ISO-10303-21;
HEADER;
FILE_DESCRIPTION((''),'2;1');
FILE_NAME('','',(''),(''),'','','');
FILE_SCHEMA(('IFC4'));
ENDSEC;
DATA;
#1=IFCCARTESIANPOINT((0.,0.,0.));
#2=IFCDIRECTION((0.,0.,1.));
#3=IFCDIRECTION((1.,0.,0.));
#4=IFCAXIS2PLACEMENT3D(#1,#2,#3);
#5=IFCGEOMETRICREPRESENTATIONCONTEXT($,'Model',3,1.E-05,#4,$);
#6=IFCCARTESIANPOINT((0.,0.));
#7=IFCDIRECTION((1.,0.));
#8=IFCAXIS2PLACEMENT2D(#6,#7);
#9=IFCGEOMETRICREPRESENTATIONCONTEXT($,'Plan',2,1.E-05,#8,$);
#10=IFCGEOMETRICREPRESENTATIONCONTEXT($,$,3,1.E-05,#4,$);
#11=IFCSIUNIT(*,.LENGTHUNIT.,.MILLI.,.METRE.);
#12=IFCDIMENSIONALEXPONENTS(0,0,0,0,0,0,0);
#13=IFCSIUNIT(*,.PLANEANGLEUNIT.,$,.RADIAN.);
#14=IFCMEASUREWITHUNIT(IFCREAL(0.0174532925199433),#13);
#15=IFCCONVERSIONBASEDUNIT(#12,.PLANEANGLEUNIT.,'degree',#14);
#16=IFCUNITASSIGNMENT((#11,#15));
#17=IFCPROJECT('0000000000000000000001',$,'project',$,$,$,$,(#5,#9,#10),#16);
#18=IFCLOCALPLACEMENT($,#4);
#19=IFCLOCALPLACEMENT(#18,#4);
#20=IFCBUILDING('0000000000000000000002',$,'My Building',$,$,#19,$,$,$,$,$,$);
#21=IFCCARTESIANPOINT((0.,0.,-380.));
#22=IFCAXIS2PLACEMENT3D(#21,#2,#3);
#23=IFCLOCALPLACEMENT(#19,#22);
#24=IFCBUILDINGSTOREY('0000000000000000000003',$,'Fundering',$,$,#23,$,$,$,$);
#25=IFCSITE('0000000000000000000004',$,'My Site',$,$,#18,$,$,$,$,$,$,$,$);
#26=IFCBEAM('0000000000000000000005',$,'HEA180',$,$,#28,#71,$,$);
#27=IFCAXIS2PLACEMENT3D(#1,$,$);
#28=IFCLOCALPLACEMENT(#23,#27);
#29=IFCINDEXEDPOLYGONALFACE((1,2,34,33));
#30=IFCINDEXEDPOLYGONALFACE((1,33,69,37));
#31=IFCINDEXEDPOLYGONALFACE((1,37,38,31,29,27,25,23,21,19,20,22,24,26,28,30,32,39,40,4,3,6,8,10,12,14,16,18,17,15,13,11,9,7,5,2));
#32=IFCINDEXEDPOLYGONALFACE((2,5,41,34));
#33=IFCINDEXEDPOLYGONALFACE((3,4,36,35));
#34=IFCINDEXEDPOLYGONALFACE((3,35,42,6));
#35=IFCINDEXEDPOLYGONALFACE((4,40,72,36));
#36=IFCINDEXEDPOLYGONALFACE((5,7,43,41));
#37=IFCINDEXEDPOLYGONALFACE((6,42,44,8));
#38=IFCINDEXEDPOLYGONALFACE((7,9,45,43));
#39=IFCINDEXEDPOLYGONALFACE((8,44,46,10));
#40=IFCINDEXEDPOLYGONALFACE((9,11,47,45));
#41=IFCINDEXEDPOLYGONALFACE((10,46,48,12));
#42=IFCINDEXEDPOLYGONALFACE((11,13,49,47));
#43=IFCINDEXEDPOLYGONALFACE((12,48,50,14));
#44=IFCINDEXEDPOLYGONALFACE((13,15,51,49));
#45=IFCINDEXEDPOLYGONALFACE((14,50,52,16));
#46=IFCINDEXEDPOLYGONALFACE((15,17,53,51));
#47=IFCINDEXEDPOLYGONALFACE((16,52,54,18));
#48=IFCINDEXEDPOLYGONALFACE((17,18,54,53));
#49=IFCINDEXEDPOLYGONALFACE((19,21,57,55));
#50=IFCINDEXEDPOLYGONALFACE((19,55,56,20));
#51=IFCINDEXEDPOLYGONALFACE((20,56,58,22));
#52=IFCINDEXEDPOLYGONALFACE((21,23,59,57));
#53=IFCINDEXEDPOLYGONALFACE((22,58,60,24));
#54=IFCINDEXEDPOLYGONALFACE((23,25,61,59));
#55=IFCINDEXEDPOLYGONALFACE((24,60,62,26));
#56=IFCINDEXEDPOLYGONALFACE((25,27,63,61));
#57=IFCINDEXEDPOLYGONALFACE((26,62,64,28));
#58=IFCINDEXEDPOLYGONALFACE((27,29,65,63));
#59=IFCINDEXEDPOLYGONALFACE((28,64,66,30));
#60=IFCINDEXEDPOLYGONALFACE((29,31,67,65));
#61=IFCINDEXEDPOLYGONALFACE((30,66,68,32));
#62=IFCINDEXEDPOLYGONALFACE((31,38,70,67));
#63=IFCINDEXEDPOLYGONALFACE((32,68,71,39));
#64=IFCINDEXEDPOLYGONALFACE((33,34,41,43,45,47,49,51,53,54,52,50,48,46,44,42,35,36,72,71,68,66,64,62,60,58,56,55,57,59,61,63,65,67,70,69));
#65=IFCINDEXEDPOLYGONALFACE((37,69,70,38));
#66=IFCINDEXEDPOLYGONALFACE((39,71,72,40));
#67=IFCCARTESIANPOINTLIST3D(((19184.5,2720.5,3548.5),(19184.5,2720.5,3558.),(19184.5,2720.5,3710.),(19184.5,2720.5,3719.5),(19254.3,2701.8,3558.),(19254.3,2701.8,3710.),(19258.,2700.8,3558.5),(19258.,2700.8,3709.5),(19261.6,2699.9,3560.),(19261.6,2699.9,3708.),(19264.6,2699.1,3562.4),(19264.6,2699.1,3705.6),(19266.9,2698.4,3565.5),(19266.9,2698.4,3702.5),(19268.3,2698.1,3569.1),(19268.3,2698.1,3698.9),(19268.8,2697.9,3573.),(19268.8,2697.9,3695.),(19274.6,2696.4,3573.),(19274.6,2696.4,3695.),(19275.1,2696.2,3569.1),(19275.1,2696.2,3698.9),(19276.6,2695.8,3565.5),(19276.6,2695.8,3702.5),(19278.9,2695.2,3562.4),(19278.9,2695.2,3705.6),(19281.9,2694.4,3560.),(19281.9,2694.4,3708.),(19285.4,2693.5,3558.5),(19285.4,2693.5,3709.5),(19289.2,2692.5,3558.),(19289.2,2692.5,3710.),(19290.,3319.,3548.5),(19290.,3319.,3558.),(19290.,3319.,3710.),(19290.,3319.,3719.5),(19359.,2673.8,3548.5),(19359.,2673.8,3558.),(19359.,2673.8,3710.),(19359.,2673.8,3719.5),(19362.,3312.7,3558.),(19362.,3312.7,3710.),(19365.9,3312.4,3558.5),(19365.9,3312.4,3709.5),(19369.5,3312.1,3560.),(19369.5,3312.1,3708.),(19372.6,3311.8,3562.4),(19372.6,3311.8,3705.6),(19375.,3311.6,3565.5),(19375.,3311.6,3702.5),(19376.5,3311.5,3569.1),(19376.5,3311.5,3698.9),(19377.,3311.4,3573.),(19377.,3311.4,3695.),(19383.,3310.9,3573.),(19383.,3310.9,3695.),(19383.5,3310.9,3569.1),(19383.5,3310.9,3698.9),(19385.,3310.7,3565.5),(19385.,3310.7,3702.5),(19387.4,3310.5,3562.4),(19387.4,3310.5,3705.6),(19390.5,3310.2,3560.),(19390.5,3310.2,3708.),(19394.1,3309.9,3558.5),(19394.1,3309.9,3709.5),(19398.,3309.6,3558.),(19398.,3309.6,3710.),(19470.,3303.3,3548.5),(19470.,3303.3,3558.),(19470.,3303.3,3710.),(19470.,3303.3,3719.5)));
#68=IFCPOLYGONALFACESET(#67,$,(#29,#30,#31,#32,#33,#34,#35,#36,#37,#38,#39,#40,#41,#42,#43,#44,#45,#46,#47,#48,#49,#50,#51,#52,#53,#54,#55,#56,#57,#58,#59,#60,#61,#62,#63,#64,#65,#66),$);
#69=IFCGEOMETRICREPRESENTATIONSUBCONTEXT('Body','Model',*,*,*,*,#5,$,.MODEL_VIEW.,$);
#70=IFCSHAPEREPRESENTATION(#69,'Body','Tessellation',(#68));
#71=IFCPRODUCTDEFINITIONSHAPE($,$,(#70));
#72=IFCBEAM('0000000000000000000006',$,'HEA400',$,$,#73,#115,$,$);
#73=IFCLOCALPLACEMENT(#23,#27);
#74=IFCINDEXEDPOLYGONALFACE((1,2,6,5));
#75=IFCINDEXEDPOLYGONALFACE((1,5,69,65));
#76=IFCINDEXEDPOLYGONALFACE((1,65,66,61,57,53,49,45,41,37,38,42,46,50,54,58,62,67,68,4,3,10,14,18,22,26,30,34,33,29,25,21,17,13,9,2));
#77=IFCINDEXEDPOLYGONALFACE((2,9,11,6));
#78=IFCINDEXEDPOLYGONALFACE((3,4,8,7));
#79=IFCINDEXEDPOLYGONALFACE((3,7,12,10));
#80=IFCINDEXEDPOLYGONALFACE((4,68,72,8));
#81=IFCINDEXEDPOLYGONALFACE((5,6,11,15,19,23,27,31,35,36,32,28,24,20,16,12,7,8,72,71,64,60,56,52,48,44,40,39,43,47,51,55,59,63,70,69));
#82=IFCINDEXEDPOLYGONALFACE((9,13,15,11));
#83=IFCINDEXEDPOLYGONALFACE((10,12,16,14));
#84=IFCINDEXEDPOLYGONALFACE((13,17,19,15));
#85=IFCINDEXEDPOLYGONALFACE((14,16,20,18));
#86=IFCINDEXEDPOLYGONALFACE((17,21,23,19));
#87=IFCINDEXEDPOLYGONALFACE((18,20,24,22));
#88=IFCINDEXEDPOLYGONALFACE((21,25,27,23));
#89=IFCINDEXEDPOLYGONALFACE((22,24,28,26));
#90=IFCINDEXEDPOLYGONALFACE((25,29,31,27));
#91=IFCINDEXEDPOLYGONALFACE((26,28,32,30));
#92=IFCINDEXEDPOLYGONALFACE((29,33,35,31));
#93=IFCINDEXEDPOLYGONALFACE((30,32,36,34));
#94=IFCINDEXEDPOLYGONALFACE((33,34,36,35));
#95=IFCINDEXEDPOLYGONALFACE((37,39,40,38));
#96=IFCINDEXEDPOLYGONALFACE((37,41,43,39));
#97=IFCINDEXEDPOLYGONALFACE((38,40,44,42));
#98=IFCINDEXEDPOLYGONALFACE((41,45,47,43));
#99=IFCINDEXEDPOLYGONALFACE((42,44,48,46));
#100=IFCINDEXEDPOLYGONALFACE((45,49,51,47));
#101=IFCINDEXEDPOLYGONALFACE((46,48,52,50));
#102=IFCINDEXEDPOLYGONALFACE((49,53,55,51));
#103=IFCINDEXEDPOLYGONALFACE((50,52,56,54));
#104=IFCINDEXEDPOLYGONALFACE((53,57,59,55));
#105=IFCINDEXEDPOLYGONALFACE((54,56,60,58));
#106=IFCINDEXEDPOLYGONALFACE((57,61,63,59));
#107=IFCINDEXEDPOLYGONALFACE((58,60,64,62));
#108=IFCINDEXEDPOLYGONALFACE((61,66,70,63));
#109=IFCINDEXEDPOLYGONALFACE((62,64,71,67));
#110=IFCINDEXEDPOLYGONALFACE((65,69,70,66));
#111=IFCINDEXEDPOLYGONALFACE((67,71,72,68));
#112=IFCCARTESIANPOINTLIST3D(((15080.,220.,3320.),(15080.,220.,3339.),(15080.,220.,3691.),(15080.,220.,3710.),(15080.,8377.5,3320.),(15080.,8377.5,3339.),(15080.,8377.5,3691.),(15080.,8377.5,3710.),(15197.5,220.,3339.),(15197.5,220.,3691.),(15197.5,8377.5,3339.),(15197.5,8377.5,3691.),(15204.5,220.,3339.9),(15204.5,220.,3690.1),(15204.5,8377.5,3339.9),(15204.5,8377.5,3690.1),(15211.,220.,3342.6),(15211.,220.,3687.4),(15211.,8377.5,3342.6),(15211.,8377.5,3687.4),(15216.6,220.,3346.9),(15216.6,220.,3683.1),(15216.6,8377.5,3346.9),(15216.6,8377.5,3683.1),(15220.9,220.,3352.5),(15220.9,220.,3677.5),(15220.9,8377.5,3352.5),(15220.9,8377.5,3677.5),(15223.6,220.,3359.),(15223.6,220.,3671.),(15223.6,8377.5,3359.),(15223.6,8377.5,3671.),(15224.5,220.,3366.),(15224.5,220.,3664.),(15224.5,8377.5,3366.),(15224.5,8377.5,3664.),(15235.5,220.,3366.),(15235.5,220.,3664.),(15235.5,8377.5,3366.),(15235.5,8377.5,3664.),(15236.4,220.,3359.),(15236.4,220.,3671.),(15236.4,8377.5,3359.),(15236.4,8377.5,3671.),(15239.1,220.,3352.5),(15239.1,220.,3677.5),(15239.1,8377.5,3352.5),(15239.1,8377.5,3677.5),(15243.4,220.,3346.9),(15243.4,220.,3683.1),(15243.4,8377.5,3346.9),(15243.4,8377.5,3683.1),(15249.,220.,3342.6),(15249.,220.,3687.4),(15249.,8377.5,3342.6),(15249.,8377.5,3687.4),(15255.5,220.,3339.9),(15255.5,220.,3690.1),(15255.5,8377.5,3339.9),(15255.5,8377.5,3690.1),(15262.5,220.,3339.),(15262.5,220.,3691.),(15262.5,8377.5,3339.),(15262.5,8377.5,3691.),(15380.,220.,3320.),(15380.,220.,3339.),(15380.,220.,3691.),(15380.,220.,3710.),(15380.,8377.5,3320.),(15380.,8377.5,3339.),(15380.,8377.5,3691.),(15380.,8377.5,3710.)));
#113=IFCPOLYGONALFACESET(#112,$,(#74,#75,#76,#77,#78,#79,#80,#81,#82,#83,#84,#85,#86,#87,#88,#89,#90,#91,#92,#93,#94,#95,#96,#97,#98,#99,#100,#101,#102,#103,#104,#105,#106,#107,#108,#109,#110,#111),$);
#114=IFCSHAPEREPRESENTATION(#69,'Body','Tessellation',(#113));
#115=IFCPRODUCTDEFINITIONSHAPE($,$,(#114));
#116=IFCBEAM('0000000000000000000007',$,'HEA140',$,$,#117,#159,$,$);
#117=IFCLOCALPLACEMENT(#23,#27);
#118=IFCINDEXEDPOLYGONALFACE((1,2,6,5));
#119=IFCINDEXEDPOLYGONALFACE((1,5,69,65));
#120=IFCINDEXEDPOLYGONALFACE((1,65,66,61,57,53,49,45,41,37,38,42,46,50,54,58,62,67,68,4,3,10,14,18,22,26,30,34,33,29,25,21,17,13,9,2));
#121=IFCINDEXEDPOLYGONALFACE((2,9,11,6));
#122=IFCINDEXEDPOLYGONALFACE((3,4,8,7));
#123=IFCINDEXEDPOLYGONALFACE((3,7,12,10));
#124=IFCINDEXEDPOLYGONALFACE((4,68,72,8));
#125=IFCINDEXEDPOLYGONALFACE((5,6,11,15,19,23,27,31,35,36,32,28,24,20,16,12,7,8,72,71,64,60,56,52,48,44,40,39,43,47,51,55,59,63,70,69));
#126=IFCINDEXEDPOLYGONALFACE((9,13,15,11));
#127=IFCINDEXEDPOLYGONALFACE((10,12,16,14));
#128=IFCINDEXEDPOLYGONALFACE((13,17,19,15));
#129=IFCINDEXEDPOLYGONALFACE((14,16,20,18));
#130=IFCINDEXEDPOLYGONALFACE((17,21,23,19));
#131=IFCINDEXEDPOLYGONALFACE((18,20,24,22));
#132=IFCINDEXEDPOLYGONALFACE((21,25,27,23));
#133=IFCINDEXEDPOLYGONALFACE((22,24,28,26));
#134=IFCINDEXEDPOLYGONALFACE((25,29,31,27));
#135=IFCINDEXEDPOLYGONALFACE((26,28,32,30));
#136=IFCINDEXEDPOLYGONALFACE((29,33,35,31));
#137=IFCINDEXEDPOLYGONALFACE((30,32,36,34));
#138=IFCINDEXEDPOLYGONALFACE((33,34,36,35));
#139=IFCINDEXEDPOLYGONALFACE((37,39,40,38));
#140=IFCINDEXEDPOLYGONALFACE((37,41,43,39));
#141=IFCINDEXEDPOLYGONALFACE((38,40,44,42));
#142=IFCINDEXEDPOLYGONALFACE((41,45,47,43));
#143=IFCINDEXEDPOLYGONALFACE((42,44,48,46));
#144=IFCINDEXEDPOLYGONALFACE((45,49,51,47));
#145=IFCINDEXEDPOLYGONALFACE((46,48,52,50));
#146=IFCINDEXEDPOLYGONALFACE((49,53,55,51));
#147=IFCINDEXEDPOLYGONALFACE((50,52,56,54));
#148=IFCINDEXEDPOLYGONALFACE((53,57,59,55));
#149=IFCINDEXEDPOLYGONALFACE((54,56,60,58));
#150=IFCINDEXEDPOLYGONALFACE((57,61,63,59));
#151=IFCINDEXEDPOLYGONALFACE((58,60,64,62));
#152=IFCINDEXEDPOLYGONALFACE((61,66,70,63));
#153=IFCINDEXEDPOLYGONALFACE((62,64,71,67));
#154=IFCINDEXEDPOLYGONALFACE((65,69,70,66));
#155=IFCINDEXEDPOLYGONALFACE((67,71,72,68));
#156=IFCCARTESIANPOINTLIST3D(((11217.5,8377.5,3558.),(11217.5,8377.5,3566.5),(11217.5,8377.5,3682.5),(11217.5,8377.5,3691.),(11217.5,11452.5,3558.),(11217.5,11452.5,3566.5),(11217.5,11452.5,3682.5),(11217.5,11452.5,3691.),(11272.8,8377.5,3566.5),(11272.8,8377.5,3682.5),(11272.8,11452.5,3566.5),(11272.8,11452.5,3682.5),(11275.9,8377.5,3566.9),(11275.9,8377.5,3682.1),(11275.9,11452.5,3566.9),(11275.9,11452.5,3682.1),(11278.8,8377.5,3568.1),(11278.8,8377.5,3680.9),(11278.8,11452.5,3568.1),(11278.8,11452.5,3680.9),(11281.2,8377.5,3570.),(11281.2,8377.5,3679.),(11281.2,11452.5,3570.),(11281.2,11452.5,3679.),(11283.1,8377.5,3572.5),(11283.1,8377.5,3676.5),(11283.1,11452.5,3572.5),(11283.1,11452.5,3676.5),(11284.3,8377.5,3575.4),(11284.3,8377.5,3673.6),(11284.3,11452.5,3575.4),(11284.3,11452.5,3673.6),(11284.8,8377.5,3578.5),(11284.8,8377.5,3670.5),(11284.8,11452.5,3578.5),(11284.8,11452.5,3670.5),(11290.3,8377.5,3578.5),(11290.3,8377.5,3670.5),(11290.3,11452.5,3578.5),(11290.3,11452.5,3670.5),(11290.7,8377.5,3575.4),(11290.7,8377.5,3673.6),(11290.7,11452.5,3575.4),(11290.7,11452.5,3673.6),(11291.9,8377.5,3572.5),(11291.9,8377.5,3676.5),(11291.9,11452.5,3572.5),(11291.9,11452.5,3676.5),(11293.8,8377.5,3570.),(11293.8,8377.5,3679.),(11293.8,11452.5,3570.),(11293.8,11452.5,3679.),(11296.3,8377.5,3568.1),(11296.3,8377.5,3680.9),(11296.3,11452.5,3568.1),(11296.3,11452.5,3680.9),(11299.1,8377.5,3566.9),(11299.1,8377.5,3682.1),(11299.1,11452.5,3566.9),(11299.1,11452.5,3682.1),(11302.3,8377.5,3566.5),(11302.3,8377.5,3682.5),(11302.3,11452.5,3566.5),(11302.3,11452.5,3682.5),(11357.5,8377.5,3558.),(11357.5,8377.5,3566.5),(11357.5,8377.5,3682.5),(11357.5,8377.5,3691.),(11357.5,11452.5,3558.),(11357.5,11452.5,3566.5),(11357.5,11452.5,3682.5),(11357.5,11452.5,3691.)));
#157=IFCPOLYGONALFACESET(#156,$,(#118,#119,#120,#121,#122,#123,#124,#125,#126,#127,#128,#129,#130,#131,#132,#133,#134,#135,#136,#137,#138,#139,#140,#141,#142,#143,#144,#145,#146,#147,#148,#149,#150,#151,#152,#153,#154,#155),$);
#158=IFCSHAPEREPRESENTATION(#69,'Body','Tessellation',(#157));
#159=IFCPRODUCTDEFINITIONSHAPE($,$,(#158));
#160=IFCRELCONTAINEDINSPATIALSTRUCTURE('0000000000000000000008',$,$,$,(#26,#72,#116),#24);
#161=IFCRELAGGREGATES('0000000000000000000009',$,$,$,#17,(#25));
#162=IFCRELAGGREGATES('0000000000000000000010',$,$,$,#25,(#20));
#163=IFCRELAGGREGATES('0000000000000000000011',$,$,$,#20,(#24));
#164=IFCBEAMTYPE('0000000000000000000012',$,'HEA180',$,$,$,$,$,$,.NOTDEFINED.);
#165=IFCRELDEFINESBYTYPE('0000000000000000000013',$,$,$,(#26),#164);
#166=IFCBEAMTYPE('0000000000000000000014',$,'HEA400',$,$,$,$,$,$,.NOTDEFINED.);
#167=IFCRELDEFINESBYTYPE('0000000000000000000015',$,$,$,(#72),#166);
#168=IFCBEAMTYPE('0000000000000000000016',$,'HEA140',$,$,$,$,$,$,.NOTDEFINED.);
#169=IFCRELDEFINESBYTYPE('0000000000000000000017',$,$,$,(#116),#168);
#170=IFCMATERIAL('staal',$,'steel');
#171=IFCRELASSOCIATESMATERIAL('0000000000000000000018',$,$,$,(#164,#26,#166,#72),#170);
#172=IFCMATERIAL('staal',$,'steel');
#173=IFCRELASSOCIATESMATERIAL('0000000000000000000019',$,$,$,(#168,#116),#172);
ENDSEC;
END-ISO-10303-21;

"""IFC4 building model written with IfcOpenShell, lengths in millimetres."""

from ifc_helpers import new_model, entity, si_unit, converted_unit, frame, origin_with_axes, origin_2d_with_axis, place, context, subcontext, project, spatial, i_section, extrude, clip, halfspace, material, material_profile, profile_set, profile_usage, type_object, element, save


model = new_model("IFC4")

# Units and contexts
model_context = context("Model", 3, precision=1e-05, world=origin_with_axes())
plan_context = context("Plan", 2, precision=1e-05, world=origin_2d_with_axis())
context_of_model = context(None, 3, precision=1e-05, world=origin_with_axes())
body_context = subcontext(model_context, "Body", "Model", "MODEL_VIEW")
ifc_project = project(units=[si_unit("LENGTHUNIT", "METRE", prefix="MILLI"), converted_unit("PLANEANGLEUNIT", "degree", entity("IfcReal", 0.0174532925199433), si_unit("PLANEANGLEUNIT", "RADIAN"), dimensions=[0, 0, 0, 0, 0, 0, 0])], contexts=[model_context, plan_context, context_of_model])

# Site, building, storey
site_placement = place(None, origin_with_axes())
site = spatial("IfcSite", under=ifc_project, at=site_placement, Name="My Site")
building_placement = place(site_placement, origin_with_axes())
building = spatial("IfcBuilding", under=site, at=building_placement, Name="My Building")
storey_placement = place(building_placement, frame((0.0, 0.0, -380.0), z_axis=(0.0, 0.0, 1.0), x_axis=(1.0, 0.0, 0.0)))
storey = spatial("IfcBuildingStorey", under=building, at=storey_placement, Name="Fundering")

# Shared definitions
ifc_material_1 = material(Name="staal", Category="steel")

# Beams
ifc_material_profile_1 = material_profile(ifc_material_1, i_section(OverallWidth=180.0, OverallDepth=171.0, WebThickness=6.0, FlangeThickness=9.5, FilletRadius=15.0))
ifc_profile_set_1 = profile_set([ifc_material_profile_1], Name="HEA180")
beam_type_1 = type_object("IfcBeamType", Name="HEA180", PredefinedType="NOTDEFINED", material=ifc_profile_set_1)
ifc_profile_usage_1 = profile_usage(ifc_profile_set_1)
beam_1_placement = place(storey_placement, frame((19501.3, 3998.8, 3634.0), z_axis=(-0.173648, -0.984808, 0.0), x_axis=(0.984808, -0.173648, 0.0)))
element("IfcBeam", 1, at=beam_1_placement, inside=storey, type_object=beam_type_1, material=ifc_profile_usage_1, Name="HEA180", context=body_context, shape_type="Clipping", body=[
    clip(clip(extrude(i_section(OverallWidth=180.0, OverallDepth=171.0, WebThickness=6.0, FlangeThickness=9.5, FilletRadius=15.0), origin_with_axes(), (0.0, 0.0, 1.0), 2020.1), halfspace(frame((90.0, -3254.0, 690.4), z_axis=(-0.087188, 0.0, -0.996192), x_axis=(0.000001, 1.0, 0.0)), False)), halfspace(frame((90.0, -3254.0, 1329.6), z_axis=(-0.087089, 0.0, 0.996201), x_axis=(0.0, 1.0, 0.0)), False)),
])
ifc_material_profile_2 = material_profile(ifc_material_1, i_section(OverallWidth=300.0, OverallDepth=390.0, WebThickness=11.0, FlangeThickness=19.0, FilletRadius=27.0))
ifc_profile_set_2 = profile_set([ifc_material_profile_2], Name="HEA400")
ifc_profile_usage_2 = profile_usage(ifc_profile_set_2, cardinal=5)
beam_type_2 = type_object("IfcBeamType", Name="HEA400", PredefinedType="NOTDEFINED", material=ifc_profile_set_2)
beam_2_placement = place(storey_placement, frame((15230.0, 220.0, 3515.0), z_axis=(0.0, 1.0, 0.0), x_axis=(-1.0, 0.0, 0.0)))
element("IfcBeam", 2, at=beam_2_placement, inside=storey, type_object=beam_type_2, material=ifc_profile_usage_2, Name="HEA400", context=body_context, shape_type="SweptSolid", body=[
    extrude(i_section(OverallWidth=300.0, OverallDepth=390.0, WebThickness=11.0, FlangeThickness=19.0, FilletRadius=27.0), origin_with_axes(), (0.0, 0.0, 1.0), 8157.5),
])
ifc_material_2 = material(Name="staal", Category="steel")
ifc_material_profile_3 = material_profile(ifc_material_2, i_section(OverallWidth=140.0, OverallDepth=133.0, WebThickness=5.5, FlangeThickness=8.5, FilletRadius=12.0))
ifc_profile_set_3 = profile_set([ifc_material_profile_3], Name="HEA140")
ifc_profile_usage_3 = profile_usage(ifc_profile_set_3)
beam_type_3 = type_object("IfcBeamType", Name="HEA140", PredefinedType="NOTDEFINED", material=ifc_profile_set_3)
beam_3_placement = place(storey_placement, frame((11287.5, 8377.5, 3624.5), z_axis=(0.0, 1.0, 0.0), x_axis=(-1.0, 0.0, 0.0)))
element("IfcBeam", 3, at=beam_3_placement, inside=storey, type_object=beam_type_3, material=ifc_profile_usage_3, Name="HEA140", context=body_context, shape_type="SweptSolid", body=[
    extrude(i_section(OverallWidth=140.0, OverallDepth=133.0, WebThickness=5.5, FlangeThickness=8.5, FilletRadius=12.0), origin_with_axes(), (0.0, 0.0, 1.0), 3075.0),
])

save(model, "model.ifc")
